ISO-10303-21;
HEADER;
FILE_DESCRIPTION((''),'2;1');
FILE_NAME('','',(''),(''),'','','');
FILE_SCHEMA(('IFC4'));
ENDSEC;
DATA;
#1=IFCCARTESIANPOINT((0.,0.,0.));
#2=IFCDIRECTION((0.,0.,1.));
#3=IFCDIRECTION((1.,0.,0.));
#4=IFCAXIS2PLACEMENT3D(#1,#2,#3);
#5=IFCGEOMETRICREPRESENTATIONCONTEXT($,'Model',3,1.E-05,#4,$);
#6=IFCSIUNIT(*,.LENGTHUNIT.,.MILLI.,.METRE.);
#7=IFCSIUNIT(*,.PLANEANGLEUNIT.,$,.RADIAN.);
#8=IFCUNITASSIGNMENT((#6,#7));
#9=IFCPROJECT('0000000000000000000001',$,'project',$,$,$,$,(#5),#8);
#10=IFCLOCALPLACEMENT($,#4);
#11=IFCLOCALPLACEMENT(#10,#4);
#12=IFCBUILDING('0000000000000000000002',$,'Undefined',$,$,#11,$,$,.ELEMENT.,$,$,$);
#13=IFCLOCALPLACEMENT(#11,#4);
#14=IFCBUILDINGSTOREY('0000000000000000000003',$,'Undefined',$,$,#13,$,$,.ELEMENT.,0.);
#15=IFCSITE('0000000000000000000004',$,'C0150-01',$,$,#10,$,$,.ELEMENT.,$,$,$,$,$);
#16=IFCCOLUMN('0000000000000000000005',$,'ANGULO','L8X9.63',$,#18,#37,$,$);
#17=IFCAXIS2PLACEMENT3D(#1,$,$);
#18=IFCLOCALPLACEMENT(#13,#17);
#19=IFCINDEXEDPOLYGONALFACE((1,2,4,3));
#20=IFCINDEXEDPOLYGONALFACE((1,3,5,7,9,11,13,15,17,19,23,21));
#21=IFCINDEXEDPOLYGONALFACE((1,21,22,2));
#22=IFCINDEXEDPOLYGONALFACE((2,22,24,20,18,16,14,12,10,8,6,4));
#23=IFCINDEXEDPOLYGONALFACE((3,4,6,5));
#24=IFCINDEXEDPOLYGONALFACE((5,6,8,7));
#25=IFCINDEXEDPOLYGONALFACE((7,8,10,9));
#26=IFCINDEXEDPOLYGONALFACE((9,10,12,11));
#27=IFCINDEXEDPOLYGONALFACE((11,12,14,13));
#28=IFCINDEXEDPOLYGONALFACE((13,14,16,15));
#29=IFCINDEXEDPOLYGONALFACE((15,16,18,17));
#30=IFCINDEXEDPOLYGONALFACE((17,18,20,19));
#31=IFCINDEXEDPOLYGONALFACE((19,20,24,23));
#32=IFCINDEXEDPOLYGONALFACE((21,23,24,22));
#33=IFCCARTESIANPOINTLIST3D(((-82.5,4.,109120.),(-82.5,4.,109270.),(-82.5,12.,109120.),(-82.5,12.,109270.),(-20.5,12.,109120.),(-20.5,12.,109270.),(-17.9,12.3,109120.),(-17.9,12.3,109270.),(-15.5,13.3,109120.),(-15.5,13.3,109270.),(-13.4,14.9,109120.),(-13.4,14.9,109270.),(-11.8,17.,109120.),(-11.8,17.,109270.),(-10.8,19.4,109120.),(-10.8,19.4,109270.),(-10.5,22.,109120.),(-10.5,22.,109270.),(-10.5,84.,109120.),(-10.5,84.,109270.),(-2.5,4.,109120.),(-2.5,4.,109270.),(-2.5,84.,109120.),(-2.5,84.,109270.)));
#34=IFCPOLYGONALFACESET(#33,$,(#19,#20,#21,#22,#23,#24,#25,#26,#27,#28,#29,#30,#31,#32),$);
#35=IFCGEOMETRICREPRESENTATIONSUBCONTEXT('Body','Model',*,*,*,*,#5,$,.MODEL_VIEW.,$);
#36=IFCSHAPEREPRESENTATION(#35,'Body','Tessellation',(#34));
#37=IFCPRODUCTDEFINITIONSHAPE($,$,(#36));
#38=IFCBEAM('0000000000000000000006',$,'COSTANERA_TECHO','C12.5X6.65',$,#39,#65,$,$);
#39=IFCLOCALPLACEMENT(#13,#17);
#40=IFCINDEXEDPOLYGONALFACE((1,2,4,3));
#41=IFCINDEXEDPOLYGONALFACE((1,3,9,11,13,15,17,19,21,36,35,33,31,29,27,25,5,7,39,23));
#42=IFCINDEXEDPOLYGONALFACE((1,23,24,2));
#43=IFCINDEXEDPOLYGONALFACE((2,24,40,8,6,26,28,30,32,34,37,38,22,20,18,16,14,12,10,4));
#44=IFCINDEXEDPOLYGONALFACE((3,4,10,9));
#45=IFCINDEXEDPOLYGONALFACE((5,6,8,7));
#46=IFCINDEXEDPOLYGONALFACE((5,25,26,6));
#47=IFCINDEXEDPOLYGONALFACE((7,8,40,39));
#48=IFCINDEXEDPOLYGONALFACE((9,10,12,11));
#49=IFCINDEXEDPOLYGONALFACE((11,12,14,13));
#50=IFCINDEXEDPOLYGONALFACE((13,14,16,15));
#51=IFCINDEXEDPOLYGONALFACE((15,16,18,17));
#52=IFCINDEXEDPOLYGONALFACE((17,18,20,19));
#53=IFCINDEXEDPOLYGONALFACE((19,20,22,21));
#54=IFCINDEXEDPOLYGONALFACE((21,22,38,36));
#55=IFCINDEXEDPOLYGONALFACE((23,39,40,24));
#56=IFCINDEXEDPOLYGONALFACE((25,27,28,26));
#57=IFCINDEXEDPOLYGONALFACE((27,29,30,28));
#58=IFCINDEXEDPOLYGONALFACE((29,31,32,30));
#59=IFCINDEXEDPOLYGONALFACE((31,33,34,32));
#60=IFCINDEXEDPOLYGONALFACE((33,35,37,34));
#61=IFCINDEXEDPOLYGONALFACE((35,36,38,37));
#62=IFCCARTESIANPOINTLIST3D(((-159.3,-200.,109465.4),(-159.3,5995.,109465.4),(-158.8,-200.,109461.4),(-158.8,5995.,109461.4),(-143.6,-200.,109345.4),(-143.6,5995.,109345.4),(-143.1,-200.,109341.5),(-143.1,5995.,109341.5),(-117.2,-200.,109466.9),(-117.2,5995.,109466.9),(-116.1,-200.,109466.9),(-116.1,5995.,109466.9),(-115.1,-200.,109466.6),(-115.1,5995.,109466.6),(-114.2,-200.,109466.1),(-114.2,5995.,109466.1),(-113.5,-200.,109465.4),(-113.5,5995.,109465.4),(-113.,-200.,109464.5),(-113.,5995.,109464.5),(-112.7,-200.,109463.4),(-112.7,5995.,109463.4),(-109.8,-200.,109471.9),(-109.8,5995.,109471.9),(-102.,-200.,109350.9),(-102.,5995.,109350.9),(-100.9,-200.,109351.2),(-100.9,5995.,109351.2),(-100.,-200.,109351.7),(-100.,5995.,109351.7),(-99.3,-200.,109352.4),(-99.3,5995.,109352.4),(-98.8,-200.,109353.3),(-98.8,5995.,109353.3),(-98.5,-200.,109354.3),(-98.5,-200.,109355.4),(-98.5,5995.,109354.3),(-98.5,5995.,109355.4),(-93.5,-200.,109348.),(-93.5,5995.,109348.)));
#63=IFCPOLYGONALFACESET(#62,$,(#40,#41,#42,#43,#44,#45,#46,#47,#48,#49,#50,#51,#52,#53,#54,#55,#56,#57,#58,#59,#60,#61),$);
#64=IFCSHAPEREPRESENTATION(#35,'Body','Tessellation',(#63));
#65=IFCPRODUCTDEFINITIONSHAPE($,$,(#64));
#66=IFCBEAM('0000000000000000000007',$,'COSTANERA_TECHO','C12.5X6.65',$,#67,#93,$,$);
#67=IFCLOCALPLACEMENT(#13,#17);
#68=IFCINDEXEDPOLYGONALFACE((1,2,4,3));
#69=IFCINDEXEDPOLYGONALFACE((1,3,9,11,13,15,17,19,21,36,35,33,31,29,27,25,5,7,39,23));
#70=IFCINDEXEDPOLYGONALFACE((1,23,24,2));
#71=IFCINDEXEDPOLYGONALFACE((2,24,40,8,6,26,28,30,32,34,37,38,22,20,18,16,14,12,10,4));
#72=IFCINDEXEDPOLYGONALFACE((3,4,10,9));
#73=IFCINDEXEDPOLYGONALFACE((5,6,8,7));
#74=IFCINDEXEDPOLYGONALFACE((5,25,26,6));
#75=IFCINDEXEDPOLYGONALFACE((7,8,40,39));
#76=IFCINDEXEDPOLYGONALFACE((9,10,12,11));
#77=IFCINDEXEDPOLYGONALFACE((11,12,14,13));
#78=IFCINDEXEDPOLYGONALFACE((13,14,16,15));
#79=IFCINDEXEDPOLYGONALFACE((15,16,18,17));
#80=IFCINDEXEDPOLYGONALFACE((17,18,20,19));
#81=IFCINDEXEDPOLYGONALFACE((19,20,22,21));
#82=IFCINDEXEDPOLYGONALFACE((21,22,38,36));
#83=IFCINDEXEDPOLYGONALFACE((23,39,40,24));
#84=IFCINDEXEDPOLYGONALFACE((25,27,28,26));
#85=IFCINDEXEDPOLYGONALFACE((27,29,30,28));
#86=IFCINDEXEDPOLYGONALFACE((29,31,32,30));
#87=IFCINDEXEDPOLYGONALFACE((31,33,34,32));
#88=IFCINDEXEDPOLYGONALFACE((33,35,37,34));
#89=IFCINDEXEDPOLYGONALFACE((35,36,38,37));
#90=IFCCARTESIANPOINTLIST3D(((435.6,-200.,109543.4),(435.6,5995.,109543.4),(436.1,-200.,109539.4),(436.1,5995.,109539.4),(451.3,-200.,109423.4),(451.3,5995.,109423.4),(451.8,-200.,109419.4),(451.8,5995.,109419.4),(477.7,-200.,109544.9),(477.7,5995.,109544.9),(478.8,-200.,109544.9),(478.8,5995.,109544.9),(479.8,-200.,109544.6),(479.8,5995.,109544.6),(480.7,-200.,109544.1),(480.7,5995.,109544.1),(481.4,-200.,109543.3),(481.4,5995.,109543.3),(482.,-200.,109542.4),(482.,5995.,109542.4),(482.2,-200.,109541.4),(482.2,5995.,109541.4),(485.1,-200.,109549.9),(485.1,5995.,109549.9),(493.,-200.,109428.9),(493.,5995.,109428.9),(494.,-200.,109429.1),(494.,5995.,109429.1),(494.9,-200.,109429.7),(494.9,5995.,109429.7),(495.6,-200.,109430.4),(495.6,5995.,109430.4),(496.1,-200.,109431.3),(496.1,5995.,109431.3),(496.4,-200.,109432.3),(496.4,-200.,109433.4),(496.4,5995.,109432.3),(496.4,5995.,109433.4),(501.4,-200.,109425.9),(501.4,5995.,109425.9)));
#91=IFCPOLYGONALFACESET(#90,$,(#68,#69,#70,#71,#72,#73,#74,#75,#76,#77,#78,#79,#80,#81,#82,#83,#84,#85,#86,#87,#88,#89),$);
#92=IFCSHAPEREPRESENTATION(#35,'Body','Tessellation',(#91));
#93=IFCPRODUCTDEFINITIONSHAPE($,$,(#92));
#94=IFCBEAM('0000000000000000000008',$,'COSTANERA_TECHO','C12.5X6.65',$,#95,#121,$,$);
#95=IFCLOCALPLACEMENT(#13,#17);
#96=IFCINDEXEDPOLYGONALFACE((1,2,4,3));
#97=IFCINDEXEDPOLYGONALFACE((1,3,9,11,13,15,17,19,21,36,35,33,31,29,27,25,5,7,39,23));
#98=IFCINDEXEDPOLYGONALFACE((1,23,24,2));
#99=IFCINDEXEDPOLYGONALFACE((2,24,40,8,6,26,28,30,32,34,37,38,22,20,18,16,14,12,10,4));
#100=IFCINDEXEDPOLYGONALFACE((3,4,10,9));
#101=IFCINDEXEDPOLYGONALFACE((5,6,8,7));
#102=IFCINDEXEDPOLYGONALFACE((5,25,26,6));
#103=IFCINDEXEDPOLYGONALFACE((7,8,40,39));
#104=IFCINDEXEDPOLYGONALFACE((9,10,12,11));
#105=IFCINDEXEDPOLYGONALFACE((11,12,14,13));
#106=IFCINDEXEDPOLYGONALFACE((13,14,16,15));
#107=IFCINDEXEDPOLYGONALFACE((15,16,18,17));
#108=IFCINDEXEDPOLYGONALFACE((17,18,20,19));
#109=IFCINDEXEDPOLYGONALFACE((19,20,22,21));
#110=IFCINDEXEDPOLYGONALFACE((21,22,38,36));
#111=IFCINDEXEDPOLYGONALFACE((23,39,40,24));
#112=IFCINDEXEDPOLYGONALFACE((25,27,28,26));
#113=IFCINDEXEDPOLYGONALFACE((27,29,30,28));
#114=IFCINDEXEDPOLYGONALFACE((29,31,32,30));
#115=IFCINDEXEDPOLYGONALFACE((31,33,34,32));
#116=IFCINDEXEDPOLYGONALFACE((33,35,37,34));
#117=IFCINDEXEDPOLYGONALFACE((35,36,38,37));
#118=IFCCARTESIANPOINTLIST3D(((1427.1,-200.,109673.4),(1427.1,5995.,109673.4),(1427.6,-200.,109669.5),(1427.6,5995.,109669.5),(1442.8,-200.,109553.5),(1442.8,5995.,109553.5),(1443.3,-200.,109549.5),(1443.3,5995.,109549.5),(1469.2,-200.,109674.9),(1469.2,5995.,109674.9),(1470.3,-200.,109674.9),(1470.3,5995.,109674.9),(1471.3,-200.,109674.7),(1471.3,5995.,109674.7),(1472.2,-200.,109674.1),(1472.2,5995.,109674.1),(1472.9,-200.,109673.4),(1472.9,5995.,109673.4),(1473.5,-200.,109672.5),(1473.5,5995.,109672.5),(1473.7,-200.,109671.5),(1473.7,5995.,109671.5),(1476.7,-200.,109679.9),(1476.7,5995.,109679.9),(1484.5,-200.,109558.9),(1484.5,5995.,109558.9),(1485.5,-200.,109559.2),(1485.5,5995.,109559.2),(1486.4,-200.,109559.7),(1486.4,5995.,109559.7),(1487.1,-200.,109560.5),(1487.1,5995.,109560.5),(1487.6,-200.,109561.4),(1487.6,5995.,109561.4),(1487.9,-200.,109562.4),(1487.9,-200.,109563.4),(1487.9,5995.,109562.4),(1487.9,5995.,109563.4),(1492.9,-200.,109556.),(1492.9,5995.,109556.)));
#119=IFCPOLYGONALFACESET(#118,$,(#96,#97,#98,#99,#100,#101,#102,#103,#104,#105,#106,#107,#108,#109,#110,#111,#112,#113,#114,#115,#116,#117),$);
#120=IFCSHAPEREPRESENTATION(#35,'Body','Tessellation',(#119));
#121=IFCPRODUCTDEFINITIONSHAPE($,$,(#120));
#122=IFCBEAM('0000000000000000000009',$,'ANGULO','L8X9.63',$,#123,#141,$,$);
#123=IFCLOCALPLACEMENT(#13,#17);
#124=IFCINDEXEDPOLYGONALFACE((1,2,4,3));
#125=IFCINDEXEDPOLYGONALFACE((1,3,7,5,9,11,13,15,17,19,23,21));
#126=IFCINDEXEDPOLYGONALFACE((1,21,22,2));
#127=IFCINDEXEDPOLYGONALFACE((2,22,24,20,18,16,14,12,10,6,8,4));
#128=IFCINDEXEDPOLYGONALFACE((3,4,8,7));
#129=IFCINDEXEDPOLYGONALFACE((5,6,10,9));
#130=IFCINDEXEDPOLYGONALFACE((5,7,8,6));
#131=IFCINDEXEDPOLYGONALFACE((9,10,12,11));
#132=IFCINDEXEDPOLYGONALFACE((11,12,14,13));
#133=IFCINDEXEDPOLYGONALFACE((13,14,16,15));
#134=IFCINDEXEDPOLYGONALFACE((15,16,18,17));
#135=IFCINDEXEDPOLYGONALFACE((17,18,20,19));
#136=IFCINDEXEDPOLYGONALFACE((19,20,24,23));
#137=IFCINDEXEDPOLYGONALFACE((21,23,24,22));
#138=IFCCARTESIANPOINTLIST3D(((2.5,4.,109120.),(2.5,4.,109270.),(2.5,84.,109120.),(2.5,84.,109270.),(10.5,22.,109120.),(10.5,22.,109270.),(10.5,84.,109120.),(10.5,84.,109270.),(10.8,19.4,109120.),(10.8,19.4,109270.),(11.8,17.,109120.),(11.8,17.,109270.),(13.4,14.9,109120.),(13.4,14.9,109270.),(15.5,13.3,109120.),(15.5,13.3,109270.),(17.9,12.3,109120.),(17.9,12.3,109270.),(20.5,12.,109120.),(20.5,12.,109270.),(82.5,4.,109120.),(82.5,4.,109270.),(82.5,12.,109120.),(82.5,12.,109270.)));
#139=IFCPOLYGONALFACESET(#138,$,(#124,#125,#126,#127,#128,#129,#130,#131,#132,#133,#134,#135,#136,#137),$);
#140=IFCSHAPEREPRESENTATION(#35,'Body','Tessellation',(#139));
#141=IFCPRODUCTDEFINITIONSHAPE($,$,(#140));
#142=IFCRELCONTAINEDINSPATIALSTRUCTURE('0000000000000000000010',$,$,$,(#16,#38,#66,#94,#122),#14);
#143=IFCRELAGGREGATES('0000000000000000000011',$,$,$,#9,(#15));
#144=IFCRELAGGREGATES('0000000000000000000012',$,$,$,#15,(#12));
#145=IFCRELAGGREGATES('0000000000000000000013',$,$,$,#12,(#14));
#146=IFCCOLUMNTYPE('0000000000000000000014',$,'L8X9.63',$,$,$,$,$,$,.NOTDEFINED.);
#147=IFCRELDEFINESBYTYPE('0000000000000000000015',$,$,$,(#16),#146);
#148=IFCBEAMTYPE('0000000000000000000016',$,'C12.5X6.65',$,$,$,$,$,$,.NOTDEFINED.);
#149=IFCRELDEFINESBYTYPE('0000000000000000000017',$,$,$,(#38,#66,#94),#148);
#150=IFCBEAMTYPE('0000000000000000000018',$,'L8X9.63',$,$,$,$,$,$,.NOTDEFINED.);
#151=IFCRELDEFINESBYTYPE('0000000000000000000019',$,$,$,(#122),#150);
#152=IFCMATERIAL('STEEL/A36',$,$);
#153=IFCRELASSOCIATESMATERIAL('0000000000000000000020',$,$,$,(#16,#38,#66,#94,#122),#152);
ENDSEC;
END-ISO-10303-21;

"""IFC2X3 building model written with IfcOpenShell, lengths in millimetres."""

from ifc_helpers import new_model, si_unit, frame, origin_with_axes, origin_2d_with_axis, place, context, subcontext, project, spatial, l_section, u_section, extrude, material, type_object, element, save


model = new_model("IFC2X3")

# Units and contexts
model_context = context("Model", 3, precision=1e-05, world=origin_with_axes())
body_context = subcontext(model_context, "Body", "Model", "MODEL_VIEW")
ifc_project = project(units=[si_unit("LENGTHUNIT", "METRE", prefix="MILLI"), si_unit("PLANEANGLEUNIT", "RADIAN")], contexts=[model_context])

# Site, building, storey
site_placement = place(None, origin_with_axes())
site = spatial("IfcSite", under=ifc_project, at=site_placement, Name="C0150-01", CompositionType="ELEMENT")
building_placement = place(site_placement, origin_with_axes())
building = spatial("IfcBuilding", under=site, at=building_placement, Name="Undefined", CompositionType="ELEMENT")
storey_placement = place(building_placement, origin_with_axes())
storey = spatial("IfcBuildingStorey", under=building, at=storey_placement, Name="Undefined", CompositionType="ELEMENT", Elevation=0.0)

# Column
ifc_material_1 = material(Name="STEEL/A36")
column_type = type_object("IfcColumnType", Name="L8X9.63", PredefinedType="NOTDEFINED")
column_placement = place(storey_placement, frame((-42.5, 44.0, 109120.0), z_axis=(0.0, 0.0, 1.0), x_axis=(0.0, 1.0, 0.0)))
element("IfcColumn", 1, at=column_placement, inside=storey, type_object=column_type, material=ifc_material_1, Name="ANGULO", Description="L8X9.63", context=body_context, shape_type="SweptSolid", body=[
    extrude(l_section(Depth=80.0, Width=80.0, Thickness=8.0, FilletRadius=10.0, at=origin_2d_with_axis()), frame((0.0, 0.0, 150.0), z_axis=(0.0, 0.0, -1.0), x_axis=(0.0, 1.0, 0.0)), (0.0, 0.0, 1.0), 150.0),
])

# Beams
beam_type_1 = type_object("IfcBeamType", Name="C12.5X6.65", PredefinedType="NOTDEFINED")
for number, where, z_axis, x_axis, name in (
    (2, (-126.4, -200.0, 109406.7), (0.130054, 0.0, -0.991507), (0.0, 1.0, 0.0), "COSTANERA_TECHO"),
    (3, (468.5, -200.0, 109484.7), (0.130054, 0.0, -0.991507), (0.0, 1.0, 0.0), "COSTANERA_TECHO"),
    (4, (1460.0, -200.0, 109614.7), (0.130054, 0.0, -0.991507), (0.0, 1.0, 0.0), "COSTANERA_TECHO"),
):
    element("IfcBeam", number, at=place(storey_placement, frame(where, z_axis=z_axis, x_axis=x_axis)), inside=storey, type_object=beam_type_1, material=ifc_material_1, Name=name, Description="C12.5X6.65", context=body_context, shape_type="SweptSolid", body=[
        extrude(u_section(Depth=125.0, FlangeWidth=50.0, WebThickness=4.0, FlangeThickness=4.0, FilletRadius=4.0, at=origin_2d_with_axis()), frame((6195.0, 0.0, 0.0), z_axis=(-1.0, 0.0, 0.0), x_axis=(0.0, -1.0, 0.0)), (0.0, 0.0, 1.0), 6195.0),
    ])
beam_type_2 = type_object("IfcBeamType", Name="L8X9.63", PredefinedType="NOTDEFINED")
beam_1_placement = place(storey_placement, frame((42.5, 44.0, 109270.0), z_axis=(0.0, 1.0, 0.0), x_axis=(0.0, 0.0, -1.0)))
element("IfcBeam", 5, at=beam_1_placement, inside=storey, type_object=beam_type_2, material=ifc_material_1, Name="ANGULO", Description="L8X9.63", context=body_context, shape_type="SweptSolid", body=[
    extrude(l_section(Depth=80.0, Width=80.0, Thickness=8.0, FilletRadius=10.0, at=origin_2d_with_axis()), frame((150.0, 0.0, 0.0), z_axis=(-1.0, 0.0, 0.0), x_axis=(0.0, -1.0, 0.0)), (0.0, 0.0, 1.0), 150.0),
])

save(model, "model.ifc")
